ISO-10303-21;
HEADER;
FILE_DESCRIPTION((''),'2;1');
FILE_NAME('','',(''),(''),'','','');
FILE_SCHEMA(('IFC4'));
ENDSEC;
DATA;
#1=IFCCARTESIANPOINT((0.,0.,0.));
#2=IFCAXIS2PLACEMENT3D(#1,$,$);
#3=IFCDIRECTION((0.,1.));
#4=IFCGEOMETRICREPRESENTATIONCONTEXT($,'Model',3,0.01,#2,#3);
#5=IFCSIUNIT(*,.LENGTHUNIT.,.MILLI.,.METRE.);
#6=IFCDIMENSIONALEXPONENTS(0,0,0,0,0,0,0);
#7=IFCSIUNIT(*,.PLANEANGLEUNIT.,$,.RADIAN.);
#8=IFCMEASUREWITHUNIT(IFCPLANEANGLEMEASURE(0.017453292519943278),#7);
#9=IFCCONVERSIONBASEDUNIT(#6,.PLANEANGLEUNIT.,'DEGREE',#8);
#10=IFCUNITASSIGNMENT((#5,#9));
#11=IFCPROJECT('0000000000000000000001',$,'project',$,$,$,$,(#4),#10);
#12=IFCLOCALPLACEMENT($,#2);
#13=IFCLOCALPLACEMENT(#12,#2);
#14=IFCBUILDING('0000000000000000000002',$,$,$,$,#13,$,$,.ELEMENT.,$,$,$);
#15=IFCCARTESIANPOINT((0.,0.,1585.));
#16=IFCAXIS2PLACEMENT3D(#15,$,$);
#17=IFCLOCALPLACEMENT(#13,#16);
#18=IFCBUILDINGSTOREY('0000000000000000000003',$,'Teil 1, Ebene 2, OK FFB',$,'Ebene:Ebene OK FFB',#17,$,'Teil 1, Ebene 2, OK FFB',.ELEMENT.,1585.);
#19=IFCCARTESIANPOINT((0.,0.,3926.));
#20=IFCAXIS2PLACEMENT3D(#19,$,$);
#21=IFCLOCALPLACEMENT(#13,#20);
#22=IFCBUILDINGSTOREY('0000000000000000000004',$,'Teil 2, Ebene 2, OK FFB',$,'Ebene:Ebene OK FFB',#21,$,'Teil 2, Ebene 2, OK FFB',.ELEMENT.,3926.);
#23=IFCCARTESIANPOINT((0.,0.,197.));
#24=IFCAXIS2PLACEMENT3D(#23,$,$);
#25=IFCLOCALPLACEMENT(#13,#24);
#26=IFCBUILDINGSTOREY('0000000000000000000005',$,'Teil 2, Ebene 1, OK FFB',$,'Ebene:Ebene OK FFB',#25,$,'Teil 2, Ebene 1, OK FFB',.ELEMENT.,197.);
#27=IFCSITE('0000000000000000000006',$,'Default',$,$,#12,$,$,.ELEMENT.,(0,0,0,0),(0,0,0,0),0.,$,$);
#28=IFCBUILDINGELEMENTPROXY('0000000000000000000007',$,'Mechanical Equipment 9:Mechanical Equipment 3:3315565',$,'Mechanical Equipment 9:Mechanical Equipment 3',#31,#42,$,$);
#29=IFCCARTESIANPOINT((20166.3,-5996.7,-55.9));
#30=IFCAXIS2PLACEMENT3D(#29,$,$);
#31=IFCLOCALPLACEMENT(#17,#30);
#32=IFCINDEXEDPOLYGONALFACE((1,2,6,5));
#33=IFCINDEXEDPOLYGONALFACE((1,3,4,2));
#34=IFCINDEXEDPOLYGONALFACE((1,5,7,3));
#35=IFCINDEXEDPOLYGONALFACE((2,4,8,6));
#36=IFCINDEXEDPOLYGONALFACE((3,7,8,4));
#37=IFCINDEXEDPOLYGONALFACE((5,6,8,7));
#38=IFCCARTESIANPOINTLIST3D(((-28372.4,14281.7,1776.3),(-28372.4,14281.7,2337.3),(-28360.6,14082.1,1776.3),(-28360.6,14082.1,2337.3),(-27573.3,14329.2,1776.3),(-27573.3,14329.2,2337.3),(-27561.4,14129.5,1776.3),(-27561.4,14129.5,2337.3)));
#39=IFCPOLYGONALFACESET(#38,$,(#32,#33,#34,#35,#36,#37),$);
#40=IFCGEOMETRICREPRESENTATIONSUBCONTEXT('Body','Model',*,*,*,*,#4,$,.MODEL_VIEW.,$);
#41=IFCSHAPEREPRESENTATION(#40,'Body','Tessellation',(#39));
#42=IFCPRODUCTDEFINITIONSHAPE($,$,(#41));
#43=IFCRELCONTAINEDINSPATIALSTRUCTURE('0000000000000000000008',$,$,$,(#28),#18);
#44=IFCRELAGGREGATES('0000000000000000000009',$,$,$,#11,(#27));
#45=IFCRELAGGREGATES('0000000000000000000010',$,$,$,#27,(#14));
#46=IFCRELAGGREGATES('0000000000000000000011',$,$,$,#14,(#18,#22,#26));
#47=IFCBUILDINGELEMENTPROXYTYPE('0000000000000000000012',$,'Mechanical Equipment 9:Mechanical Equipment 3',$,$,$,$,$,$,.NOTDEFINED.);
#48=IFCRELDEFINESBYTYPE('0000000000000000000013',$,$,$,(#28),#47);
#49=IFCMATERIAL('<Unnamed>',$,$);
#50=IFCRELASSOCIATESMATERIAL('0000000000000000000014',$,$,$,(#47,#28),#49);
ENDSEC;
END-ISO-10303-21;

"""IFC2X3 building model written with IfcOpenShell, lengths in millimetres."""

from ifc_helpers import new_model, entity, si_unit, converted_unit, direction, frame, frame_2d, origin, place, context, subcontext, project, spatial, rectangle, extrude, source, transform, mapped, material, type_object, type_shapes, element, save


model = new_model("IFC2X3")

# Units and contexts
model_context = context("Model", 3, precision=0.01, world=origin(), true_north=direction((0.0, 1.0)))
body_context = subcontext(model_context, "Body", "Model", "MODEL_VIEW")
ifc_project = project(units=[si_unit("LENGTHUNIT", "METRE", prefix="MILLI"), converted_unit("PLANEANGLEUNIT", "DEGREE", entity("IfcPlaneAngleMeasure", 0.017453292519943278), si_unit("PLANEANGLEUNIT", "RADIAN"), dimensions=[0, 0, 0, 0, 0, 0, 0])], contexts=[model_context])

# Site, building, storey
site_placement = place(None, origin())
site = spatial("IfcSite", under=ifc_project, at=site_placement, Name="Default", CompositionType="ELEMENT", RefLatitude=(0, 0, 0, 0), RefLongitude=(0, 0, 0, 0), RefElevation=0.0)
building_placement = place(site_placement, origin())
building = spatial("IfcBuilding", under=site, at=building_placement, CompositionType="ELEMENT")
storey_1_placement = place(building_placement, frame((0.0, 0.0, 1585.0)))
storey_1 = spatial("IfcBuildingStorey", under=building, at=storey_1_placement, Name="Teil 1, Ebene 2, OK FFB", ObjectType="Ebene:Ebene OK FFB", LongName="Teil 1, Ebene 2, OK FFB", CompositionType="ELEMENT", Elevation=1585.0)

# Shared definitions
storey_2_placement = place(building_placement, frame((0.0, 0.0, 3926.0)))
storey_2 = spatial("IfcBuildingStorey", under=building, at=storey_2_placement, Name="Teil 2, Ebene 2, OK FFB", ObjectType="Ebene:Ebene OK FFB", LongName="Teil 2, Ebene 2, OK FFB", CompositionType="ELEMENT", Elevation=3926.0)

# Shared definitions
storey_3_placement = place(building_placement, frame((0.0, 0.0, 197.0)))
storey_3 = spatial("IfcBuildingStorey", under=building, at=storey_3_placement, Name="Teil 2, Ebene 1, OK FFB", ObjectType="Ebene:Ebene OK FFB", LongName="Teil 2, Ebene 1, OK FFB", CompositionType="ELEMENT", Elevation=197.0)

# Building element proxy
ifc_material_1 = material(Name="<Unnamed>")
building_element_proxy_type = type_object("IfcBuildingElementProxyType", Name="Mechanical Equipment 9:Mechanical Equipment 3", PredefinedType="NOTDEFINED", material=ifc_material_1)
shared_shape_1 = source(origin(), body_context, "Body", "SweptSolid", [
    extrude(rectangle(XDim=200.0, YDim=800.5, at=frame_2d((0.0, 0.0), x_axis=(1.0, 0.0))), frame((-27966.9, 14205.6, 1776.3), z_axis=(0.0, 0.0, 1.0), x_axis=(0.059319, -0.998239, 0.0)), (0.0, 0.0, 1.0), 561.1),
])
type_shapes(building_element_proxy_type, [shared_shape_1])
proxy_placement = place(storey_1_placement, frame((20166.3, -5996.7, -55.9)))
element("IfcBuildingElementProxy", 1, at=proxy_placement, inside=storey_1, type_object=building_element_proxy_type, material=ifc_material_1, Name="Mechanical Equipment 9:Mechanical Equipment 3:3315565", ObjectType="Mechanical Equipment 9:Mechanical Equipment 3", context=body_context, shape_type="MappedRepresentation", body=[
    mapped(shared_shape_1, transform((0.0, 0.0, 0.0), scale=1.0)),
])

save(model, "model.ifc")
